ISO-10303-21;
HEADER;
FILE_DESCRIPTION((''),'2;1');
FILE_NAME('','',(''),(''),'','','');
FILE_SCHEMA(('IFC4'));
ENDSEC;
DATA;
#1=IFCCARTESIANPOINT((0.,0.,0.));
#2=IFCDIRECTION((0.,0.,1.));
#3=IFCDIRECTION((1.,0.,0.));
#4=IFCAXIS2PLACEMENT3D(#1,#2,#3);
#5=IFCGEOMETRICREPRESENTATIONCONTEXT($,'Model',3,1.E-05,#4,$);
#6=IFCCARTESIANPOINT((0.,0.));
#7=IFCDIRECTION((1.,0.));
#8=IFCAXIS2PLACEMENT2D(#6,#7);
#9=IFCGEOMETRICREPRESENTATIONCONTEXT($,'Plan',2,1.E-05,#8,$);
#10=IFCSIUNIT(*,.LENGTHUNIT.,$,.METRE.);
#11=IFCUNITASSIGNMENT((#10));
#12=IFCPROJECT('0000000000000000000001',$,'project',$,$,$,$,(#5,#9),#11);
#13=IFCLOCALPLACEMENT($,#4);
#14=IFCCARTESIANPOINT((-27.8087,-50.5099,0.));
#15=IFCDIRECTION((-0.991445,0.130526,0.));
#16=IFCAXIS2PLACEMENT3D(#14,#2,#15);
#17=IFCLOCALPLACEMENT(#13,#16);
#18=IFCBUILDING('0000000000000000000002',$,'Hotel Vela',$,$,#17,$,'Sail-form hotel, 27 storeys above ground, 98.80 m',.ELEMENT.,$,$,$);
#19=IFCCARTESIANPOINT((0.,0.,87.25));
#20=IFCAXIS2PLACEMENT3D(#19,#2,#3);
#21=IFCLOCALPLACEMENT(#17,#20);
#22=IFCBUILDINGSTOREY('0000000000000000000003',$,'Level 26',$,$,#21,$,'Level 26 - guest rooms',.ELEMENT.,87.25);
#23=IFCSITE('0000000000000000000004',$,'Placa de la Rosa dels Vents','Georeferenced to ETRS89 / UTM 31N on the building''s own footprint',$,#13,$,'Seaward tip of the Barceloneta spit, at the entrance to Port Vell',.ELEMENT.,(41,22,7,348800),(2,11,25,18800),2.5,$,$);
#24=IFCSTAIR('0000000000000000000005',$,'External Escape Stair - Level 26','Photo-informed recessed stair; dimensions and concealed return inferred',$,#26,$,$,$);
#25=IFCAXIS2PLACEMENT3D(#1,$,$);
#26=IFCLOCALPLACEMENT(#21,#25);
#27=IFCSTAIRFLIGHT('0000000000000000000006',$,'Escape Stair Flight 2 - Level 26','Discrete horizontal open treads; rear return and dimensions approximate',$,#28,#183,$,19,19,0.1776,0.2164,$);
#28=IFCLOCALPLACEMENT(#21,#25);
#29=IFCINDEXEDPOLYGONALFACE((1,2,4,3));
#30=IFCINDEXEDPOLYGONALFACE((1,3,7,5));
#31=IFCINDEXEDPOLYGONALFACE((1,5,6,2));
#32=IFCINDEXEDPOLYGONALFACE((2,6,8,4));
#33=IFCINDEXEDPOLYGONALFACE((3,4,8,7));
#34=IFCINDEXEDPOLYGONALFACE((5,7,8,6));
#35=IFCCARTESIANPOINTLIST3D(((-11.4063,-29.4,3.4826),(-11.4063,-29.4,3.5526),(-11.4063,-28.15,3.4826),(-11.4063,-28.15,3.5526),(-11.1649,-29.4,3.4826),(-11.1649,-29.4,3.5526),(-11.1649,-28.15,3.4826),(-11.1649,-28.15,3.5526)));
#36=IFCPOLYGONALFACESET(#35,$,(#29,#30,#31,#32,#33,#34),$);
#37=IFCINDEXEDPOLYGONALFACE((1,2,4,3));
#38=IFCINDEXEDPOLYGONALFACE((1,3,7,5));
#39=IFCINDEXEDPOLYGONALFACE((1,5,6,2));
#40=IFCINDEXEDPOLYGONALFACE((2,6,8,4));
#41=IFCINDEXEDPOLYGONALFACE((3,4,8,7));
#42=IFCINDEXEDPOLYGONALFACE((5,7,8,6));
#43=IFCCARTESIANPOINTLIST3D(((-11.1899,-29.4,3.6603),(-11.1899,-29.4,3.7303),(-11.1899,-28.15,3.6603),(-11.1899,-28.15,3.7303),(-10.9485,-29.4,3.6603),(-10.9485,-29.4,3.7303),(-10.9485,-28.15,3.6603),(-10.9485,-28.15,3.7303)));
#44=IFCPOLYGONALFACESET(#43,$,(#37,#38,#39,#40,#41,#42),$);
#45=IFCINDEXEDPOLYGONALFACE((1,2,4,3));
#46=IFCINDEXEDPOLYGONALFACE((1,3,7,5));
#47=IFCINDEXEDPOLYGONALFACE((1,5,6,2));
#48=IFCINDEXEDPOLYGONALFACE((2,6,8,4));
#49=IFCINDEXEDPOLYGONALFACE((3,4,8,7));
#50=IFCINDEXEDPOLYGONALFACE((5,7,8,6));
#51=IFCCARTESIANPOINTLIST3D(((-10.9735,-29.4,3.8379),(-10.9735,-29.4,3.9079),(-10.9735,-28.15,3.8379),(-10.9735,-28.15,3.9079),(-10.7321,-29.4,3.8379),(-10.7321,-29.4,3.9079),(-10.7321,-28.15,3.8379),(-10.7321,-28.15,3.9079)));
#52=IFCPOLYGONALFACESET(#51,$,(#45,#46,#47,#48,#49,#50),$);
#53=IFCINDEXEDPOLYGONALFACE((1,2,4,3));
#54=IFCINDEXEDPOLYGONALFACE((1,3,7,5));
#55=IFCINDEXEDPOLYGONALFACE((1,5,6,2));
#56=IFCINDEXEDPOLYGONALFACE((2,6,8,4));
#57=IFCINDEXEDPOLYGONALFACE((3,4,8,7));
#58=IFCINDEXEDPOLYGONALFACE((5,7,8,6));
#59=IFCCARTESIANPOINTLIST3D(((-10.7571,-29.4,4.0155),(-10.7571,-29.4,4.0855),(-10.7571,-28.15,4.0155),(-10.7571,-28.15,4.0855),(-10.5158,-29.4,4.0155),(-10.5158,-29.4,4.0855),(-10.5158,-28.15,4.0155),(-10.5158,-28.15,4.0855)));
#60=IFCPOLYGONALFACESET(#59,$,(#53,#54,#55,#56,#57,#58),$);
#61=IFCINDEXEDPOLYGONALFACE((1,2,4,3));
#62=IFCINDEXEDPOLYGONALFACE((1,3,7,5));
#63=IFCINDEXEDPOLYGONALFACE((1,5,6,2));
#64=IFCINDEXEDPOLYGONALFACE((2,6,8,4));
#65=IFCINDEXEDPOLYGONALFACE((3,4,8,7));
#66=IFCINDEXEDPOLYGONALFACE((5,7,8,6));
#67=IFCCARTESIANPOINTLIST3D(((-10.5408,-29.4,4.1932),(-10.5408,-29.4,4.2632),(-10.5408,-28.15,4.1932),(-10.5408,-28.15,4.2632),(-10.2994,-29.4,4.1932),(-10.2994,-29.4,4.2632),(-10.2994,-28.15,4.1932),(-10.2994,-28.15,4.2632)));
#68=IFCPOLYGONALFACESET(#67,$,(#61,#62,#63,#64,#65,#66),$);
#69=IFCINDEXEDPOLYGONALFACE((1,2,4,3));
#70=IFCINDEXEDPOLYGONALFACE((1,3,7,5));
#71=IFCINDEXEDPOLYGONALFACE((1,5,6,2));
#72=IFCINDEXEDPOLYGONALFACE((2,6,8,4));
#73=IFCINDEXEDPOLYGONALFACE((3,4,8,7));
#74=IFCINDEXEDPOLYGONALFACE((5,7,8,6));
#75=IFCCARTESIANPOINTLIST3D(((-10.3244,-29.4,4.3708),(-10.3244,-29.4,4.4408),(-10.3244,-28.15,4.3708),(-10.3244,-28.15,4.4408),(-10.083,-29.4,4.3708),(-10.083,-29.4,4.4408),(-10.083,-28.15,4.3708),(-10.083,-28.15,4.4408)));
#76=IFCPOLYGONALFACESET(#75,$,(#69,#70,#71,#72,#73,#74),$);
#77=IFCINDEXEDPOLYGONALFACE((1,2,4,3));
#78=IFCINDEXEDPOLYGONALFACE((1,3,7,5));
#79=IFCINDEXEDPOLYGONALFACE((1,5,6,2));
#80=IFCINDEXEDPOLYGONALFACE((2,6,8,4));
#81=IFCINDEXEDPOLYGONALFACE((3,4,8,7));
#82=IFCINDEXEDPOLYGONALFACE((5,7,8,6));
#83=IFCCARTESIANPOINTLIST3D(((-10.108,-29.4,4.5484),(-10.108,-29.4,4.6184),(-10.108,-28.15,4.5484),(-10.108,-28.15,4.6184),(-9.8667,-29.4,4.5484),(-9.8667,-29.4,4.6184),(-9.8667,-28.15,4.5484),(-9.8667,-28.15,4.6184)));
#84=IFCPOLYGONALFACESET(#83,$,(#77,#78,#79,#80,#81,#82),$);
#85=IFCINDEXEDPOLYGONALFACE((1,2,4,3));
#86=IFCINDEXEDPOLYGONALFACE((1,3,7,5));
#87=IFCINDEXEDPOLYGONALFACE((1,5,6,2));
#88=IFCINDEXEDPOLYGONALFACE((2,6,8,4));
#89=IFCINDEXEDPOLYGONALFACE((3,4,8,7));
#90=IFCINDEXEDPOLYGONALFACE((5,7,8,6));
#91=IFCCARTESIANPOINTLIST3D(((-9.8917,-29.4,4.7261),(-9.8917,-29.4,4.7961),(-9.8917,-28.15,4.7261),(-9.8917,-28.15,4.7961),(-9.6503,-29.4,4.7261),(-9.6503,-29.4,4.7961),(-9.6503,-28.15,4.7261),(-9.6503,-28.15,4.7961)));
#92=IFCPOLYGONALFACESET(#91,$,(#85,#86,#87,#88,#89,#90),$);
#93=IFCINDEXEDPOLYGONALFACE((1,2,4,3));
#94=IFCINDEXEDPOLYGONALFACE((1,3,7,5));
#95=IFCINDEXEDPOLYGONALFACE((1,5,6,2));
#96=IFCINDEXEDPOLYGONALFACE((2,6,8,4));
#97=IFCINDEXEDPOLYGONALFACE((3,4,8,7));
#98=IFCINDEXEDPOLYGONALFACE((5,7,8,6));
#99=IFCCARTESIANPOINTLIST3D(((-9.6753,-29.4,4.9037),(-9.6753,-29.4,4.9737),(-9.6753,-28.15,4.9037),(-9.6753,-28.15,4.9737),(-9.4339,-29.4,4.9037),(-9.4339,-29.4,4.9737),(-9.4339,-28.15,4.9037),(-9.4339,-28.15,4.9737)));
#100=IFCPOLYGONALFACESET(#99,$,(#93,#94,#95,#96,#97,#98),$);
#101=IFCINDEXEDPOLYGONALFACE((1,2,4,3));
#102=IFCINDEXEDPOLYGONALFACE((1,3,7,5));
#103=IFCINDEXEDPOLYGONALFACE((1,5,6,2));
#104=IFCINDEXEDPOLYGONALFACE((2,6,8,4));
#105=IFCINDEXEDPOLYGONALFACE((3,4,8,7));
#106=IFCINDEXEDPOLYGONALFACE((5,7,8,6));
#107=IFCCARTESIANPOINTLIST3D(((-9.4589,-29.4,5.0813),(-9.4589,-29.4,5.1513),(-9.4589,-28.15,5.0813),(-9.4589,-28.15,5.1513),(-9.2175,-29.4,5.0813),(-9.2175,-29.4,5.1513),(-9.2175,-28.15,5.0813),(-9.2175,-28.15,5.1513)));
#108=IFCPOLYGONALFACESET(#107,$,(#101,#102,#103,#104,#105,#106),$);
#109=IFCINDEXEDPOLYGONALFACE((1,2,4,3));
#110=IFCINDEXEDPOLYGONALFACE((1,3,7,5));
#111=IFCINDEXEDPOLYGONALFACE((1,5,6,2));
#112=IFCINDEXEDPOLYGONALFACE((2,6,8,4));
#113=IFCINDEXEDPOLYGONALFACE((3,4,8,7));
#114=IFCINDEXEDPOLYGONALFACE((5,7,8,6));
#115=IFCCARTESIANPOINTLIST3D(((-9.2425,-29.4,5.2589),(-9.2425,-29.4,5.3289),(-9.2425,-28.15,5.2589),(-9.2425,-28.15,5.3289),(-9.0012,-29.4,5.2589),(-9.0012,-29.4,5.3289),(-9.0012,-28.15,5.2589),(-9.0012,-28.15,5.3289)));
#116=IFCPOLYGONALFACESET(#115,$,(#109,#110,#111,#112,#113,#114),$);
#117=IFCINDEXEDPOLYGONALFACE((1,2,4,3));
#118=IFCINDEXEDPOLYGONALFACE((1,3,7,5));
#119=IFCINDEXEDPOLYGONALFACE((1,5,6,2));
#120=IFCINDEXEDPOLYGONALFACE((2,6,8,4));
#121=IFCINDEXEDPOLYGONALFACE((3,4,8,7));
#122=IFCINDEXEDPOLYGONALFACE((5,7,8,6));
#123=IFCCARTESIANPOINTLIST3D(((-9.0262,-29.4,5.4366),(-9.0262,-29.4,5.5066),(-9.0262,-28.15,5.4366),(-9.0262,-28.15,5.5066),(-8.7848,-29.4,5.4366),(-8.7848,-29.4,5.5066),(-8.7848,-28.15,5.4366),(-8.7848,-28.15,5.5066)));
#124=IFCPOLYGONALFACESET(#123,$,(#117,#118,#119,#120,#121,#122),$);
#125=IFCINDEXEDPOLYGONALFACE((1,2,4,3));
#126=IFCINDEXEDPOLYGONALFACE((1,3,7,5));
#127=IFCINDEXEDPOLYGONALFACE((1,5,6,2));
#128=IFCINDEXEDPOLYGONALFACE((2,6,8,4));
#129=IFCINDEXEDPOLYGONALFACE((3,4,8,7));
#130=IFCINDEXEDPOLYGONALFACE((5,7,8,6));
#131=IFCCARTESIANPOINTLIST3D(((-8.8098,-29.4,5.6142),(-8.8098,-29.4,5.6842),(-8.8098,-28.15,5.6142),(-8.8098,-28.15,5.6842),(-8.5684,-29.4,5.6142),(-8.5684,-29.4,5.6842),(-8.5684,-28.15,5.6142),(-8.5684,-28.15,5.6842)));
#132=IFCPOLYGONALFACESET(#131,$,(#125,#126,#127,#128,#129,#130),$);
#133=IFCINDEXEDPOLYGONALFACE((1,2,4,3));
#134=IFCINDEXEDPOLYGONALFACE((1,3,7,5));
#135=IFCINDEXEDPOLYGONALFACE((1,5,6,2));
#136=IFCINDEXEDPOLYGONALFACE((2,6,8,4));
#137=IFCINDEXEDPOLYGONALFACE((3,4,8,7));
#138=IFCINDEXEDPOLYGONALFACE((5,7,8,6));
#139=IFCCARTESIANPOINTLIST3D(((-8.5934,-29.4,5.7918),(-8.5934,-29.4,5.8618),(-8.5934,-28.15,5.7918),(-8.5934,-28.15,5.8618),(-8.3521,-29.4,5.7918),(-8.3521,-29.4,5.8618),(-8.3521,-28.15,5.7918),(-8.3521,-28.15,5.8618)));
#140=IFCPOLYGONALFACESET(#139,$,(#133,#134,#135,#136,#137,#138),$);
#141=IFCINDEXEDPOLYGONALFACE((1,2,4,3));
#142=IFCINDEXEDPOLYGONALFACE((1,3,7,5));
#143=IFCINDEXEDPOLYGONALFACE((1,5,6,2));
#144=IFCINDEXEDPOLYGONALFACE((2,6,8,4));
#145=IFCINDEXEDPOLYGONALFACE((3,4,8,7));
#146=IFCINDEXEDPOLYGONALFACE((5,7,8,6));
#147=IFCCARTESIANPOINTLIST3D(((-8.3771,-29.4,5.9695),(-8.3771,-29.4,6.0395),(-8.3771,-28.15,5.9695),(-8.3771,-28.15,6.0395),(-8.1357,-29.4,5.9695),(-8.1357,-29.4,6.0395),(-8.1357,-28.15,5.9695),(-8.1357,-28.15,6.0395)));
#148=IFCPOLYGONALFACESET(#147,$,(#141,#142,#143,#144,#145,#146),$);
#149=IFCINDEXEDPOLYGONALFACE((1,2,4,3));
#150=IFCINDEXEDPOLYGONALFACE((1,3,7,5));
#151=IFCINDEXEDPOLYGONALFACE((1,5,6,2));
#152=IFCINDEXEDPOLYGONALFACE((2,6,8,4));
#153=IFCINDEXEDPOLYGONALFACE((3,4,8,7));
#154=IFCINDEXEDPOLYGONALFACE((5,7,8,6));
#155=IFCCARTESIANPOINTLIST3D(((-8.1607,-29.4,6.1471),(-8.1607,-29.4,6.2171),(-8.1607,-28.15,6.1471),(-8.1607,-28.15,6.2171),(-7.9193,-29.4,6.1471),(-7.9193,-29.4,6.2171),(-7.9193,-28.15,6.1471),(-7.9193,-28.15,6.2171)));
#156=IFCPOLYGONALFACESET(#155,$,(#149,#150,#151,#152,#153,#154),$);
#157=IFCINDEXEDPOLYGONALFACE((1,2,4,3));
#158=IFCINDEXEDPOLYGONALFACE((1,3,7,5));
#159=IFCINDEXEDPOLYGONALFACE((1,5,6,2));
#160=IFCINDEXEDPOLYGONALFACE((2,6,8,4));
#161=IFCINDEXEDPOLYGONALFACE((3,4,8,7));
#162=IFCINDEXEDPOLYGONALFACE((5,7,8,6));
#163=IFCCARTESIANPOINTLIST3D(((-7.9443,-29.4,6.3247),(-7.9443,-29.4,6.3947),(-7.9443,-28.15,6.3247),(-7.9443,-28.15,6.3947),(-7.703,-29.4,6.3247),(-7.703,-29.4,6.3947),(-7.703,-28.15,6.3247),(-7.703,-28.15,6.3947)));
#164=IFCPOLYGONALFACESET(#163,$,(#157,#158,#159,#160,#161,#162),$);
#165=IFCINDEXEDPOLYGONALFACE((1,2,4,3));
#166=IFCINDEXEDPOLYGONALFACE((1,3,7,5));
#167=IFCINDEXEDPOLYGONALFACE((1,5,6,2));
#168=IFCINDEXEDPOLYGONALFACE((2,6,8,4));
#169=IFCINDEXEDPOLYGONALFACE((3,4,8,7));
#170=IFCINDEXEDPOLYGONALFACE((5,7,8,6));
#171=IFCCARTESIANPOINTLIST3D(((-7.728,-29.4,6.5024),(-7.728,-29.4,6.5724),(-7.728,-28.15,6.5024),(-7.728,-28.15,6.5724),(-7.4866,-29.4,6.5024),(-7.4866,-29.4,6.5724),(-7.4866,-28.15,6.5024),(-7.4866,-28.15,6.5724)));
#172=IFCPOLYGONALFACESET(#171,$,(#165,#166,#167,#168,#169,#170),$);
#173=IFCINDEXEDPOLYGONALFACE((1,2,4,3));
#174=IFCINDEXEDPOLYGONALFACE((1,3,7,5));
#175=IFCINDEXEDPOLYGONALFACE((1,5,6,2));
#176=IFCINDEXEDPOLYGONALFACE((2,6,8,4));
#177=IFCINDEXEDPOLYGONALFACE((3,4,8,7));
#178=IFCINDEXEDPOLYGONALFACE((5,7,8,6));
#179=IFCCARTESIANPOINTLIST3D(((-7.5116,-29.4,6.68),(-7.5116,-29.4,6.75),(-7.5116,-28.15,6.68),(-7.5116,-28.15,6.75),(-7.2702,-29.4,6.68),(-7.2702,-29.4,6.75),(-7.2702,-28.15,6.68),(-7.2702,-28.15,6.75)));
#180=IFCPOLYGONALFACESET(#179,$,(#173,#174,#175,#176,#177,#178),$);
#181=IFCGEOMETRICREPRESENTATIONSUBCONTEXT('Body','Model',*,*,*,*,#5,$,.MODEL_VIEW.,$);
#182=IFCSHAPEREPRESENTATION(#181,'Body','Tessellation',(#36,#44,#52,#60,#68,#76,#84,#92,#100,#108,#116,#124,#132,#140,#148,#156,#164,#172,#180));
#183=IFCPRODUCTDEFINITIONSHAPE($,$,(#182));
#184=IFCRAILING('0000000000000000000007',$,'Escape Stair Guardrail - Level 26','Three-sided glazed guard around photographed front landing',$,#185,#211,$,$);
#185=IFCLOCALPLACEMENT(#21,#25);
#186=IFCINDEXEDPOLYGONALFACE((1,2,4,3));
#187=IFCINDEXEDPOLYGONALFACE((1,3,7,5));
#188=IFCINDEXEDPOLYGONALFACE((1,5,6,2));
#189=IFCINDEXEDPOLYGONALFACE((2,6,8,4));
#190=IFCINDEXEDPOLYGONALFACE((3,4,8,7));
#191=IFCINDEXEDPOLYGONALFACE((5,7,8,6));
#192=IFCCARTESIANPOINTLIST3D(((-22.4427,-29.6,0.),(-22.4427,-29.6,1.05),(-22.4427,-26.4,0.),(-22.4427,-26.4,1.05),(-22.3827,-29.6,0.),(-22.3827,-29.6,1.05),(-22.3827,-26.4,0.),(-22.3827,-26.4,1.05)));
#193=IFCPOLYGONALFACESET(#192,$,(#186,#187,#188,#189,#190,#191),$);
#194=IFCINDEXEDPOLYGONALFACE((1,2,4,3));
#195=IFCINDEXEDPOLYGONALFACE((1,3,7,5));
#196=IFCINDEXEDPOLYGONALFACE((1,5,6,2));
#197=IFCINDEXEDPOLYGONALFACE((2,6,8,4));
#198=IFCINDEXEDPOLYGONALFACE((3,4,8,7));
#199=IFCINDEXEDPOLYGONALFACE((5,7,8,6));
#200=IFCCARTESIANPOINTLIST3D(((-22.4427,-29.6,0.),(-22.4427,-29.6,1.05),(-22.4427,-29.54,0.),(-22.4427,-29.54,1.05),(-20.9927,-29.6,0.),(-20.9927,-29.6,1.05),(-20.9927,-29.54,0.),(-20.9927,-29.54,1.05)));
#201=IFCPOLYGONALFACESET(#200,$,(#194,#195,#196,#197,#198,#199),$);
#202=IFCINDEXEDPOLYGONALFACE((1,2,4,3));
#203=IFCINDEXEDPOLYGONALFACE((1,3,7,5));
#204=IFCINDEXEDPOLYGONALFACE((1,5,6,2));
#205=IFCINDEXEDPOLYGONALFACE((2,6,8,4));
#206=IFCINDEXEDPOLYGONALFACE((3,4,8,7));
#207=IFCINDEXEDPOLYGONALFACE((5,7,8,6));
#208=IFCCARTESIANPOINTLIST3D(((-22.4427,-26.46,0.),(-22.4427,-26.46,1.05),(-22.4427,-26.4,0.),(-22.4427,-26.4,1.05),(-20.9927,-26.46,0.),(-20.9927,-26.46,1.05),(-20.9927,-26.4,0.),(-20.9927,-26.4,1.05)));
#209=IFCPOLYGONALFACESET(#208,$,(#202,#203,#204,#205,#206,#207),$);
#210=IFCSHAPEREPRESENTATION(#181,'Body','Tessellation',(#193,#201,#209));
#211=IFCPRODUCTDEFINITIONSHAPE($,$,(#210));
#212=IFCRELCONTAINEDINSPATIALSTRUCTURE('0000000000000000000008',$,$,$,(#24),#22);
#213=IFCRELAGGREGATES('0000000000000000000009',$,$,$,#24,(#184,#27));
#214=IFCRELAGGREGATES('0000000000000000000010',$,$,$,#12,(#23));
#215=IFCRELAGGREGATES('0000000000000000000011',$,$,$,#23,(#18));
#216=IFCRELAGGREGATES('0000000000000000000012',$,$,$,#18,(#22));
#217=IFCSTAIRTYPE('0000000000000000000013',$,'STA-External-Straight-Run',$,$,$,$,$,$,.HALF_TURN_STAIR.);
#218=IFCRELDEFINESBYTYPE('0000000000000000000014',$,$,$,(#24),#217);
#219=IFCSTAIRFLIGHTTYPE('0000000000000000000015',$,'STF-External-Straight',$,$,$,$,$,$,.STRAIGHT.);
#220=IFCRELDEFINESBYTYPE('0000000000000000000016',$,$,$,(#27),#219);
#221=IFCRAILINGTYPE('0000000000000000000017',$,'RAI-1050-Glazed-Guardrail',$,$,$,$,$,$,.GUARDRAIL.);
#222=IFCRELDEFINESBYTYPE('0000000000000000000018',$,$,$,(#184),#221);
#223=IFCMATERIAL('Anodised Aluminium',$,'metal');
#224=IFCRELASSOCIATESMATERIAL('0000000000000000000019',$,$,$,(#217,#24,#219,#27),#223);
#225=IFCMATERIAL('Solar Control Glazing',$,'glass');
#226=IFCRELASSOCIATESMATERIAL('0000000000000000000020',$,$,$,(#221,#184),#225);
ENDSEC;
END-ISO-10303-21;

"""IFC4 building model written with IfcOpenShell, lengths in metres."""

from ifc_helpers import new_model, si_unit, frame, origin_with_axes, origin_2d_with_axis, place, context, subcontext, project, spatial, line, indexed_curve, outline, extrude, material, type_object, element, aggregate, save


model = new_model("IFC4")

# Units and contexts
model_context = context("Model", 3, precision=1e-05, world=origin_with_axes())
plan_context = context("Plan", 2, precision=1e-05, world=origin_2d_with_axis())
body_context = subcontext(model_context, "Body", "Model", "MODEL_VIEW")
ifc_project = project(units=[si_unit("LENGTHUNIT", "METRE")], contexts=[model_context, plan_context])

# Site, building, storey
site_placement = place(None, origin_with_axes())
site = spatial("IfcSite", under=ifc_project, at=site_placement, Name="Placa de la Rosa dels Vents", Description="Georeferenced to ETRS89 / UTM 31N on the building's own footprint", LongName="Seaward tip of the Barceloneta spit, at the entrance to Port Vell", CompositionType="ELEMENT", RefLatitude=(41, 22, 7, 348800), RefLongitude=(2, 11, 25, 18800), RefElevation=2.5)
building_placement = place(site_placement, frame((-27.8087, -50.5099, 0.0), z_axis=(0.0, 0.0, 1.0), x_axis=(-0.991445, 0.130526, 0.0)))
building = spatial("IfcBuilding", under=site, at=building_placement, Name="Hotel Vela", LongName="Sail-form hotel, 27 storeys above ground, 98.80 m", CompositionType="ELEMENT")
storey_placement = place(building_placement, frame((0.0, 0.0, 87.25), z_axis=(0.0, 0.0, 1.0), x_axis=(1.0, 0.0, 0.0)))
storey = spatial("IfcBuildingStorey", under=building, at=storey_placement, Name="Level 26", LongName="Level 26 - guest rooms", CompositionType="ELEMENT", Elevation=87.25)

# Stair
ifc_material_1 = material(Name="Anodised Aluminium", Category="metal")
stair_type = type_object("IfcStairType", Name="STA-External-Straight-Run", PredefinedType="HALF_TURN_STAIR", material=ifc_material_1)
stair_placement = place(storey_placement, frame((0.0, 0.0, -87.25), z_axis=(0.0, 0.0, 1.0), x_axis=(1.0, 0.0, 0.0)))
stair = element("IfcStair", 1, at=stair_placement, inside=storey, type_object=stair_type, material=ifc_material_1, Name="External Escape Stair - Level 26", Description="Photo-informed recessed stair; dimensions and concealed return inferred")

# Stair flight
stair_flight_type = type_object("IfcStairFlightType", Name="STF-External-Straight", PredefinedType="STRAIGHT", material=ifc_material_1)
stair_flight_1_placement = place(stair_placement, origin_with_axes())
stair_flight_1 = element("IfcStairFlight", 2, at=stair_flight_1_placement, type_object=stair_flight_type, material=ifc_material_1, Name="Escape Stair Flight 2 - Level 26", Description="Discrete horizontal open treads; rear return and dimensions approximate", NumberOfRisers=19, NumberOfTreads=19, RiserHeight=0.1776, TreadLength=0.2164, context=body_context, shape_type="SweptSolid", body=[
    extrude(outline(indexed_curve([(0.0, 0.0), (0.2414, 0.0), (0.2414, 1.25), (0.0, 1.25)], segments=[line(1, 2, 3, 4, 1)])), frame((-11.4063, -29.4, 90.7326), z_axis=(0.0, 0.0, 1.0), x_axis=(1.0, 0.0, 0.0)), (0.0, 0.0, 1.0), 0.07),
    extrude(outline(indexed_curve([(0.0, 0.0), (0.2414, 0.0), (0.2414, 1.25), (0.0, 1.25)], segments=[line(1, 2, 3, 4, 1)])), frame((-11.1899, -29.4, 90.9103), z_axis=(0.0, 0.0, 1.0), x_axis=(1.0, 0.0, 0.0)), (0.0, 0.0, 1.0), 0.07),
    extrude(outline(indexed_curve([(0.0, 0.0), (0.2414, 0.0), (0.2414, 1.25), (0.0, 1.25)], segments=[line(1, 2, 3, 4, 1)])), frame((-10.9735, -29.4, 91.0879), z_axis=(0.0, 0.0, 1.0), x_axis=(1.0, 0.0, 0.0)), (0.0, 0.0, 1.0), 0.07),
    extrude(outline(indexed_curve([(0.0, 0.0), (0.2414, 0.0), (0.2414, 1.25), (0.0, 1.25)], segments=[line(1, 2, 3, 4, 1)])), frame((-10.7571, -29.4, 91.2655), z_axis=(0.0, 0.0, 1.0), x_axis=(1.0, 0.0, 0.0)), (0.0, 0.0, 1.0), 0.07),
    extrude(outline(indexed_curve([(0.0, 0.0), (0.2414, 0.0), (0.2414, 1.25), (0.0, 1.25)], segments=[line(1, 2, 3, 4, 1)])), frame((-10.5408, -29.4, 91.4432), z_axis=(0.0, 0.0, 1.0), x_axis=(1.0, 0.0, 0.0)), (0.0, 0.0, 1.0), 0.07),
    extrude(outline(indexed_curve([(0.0, 0.0), (0.2414, 0.0), (0.2414, 1.25), (0.0, 1.25)], segments=[line(1, 2, 3, 4, 1)])), frame((-10.3244, -29.4, 91.6208), z_axis=(0.0, 0.0, 1.0), x_axis=(1.0, 0.0, 0.0)), (0.0, 0.0, 1.0), 0.07),
    extrude(outline(indexed_curve([(0.0, 0.0), (0.2414, 0.0), (0.2414, 1.25), (0.0, 1.25)], segments=[line(1, 2, 3, 4, 1)])), frame((-10.108, -29.4, 91.7984), z_axis=(0.0, 0.0, 1.0), x_axis=(1.0, 0.0, 0.0)), (0.0, 0.0, 1.0), 0.07),
    extrude(outline(indexed_curve([(0.0, 0.0), (0.2414, 0.0), (0.2414, 1.25), (0.0, 1.25)], segments=[line(1, 2, 3, 4, 1)])), frame((-9.8917, -29.4, 91.9761), z_axis=(0.0, 0.0, 1.0), x_axis=(1.0, 0.0, 0.0)), (0.0, 0.0, 1.0), 0.07),
    extrude(outline(indexed_curve([(0.0, 0.0), (0.2414, 0.0), (0.2414, 1.25), (0.0, 1.25)], segments=[line(1, 2, 3, 4, 1)])), frame((-9.6753, -29.4, 92.1537), z_axis=(0.0, 0.0, 1.0), x_axis=(1.0, 0.0, 0.0)), (0.0, 0.0, 1.0), 0.07),
    extrude(outline(indexed_curve([(0.0, 0.0), (0.2414, 0.0), (0.2414, 1.25), (0.0, 1.25)], segments=[line(1, 2, 3, 4, 1)])), frame((-9.4589, -29.4, 92.3313), z_axis=(0.0, 0.0, 1.0), x_axis=(1.0, 0.0, 0.0)), (0.0, 0.0, 1.0), 0.07),
    extrude(outline(indexed_curve([(0.0, 0.0), (0.2414, 0.0), (0.2414, 1.25), (0.0, 1.25)], segments=[line(1, 2, 3, 4, 1)])), frame((-9.2425, -29.4, 92.5089), z_axis=(0.0, 0.0, 1.0), x_axis=(1.0, 0.0, 0.0)), (0.0, 0.0, 1.0), 0.07),
    extrude(outline(indexed_curve([(0.0, 0.0), (0.2414, 0.0), (0.2414, 1.25), (0.0, 1.25)], segments=[line(1, 2, 3, 4, 1)])), frame((-9.0262, -29.4, 92.6866), z_axis=(0.0, 0.0, 1.0), x_axis=(1.0, 0.0, 0.0)), (0.0, 0.0, 1.0), 0.07),
    extrude(outline(indexed_curve([(0.0, 0.0), (0.2414, 0.0), (0.2414, 1.25), (0.0, 1.25)], segments=[line(1, 2, 3, 4, 1)])), frame((-8.8098, -29.4, 92.8642), z_axis=(0.0, 0.0, 1.0), x_axis=(1.0, 0.0, 0.0)), (0.0, 0.0, 1.0), 0.07),
    extrude(outline(indexed_curve([(0.0, 0.0), (0.2414, 0.0), (0.2414, 1.25), (0.0, 1.25)], segments=[line(1, 2, 3, 4, 1)])), frame((-8.5934, -29.4, 93.0418), z_axis=(0.0, 0.0, 1.0), x_axis=(1.0, 0.0, 0.0)), (0.0, 0.0, 1.0), 0.07),
    extrude(outline(indexed_curve([(0.0, 0.0), (0.2414, 0.0), (0.2414, 1.25), (0.0, 1.25)], segments=[line(1, 2, 3, 4, 1)])), frame((-8.3771, -29.4, 93.2195), z_axis=(0.0, 0.0, 1.0), x_axis=(1.0, 0.0, 0.0)), (0.0, 0.0, 1.0), 0.07),
    extrude(outline(indexed_curve([(0.0, 0.0), (0.2414, 0.0), (0.2414, 1.25), (0.0, 1.25)], segments=[line(1, 2, 3, 4, 1)])), frame((-8.1607, -29.4, 93.3971), z_axis=(0.0, 0.0, 1.0), x_axis=(1.0, 0.0, 0.0)), (0.0, 0.0, 1.0), 0.07),
    extrude(outline(indexed_curve([(0.0, 0.0), (0.2414, 0.0), (0.2414, 1.25), (0.0, 1.25)], segments=[line(1, 2, 3, 4, 1)])), frame((-7.9443, -29.4, 93.5747), z_axis=(0.0, 0.0, 1.0), x_axis=(1.0, 0.0, 0.0)), (0.0, 0.0, 1.0), 0.07),
    extrude(outline(indexed_curve([(0.0, 0.0), (0.2414, 0.0), (0.2414, 1.25), (0.0, 1.25)], segments=[line(1, 2, 3, 4, 1)])), frame((-7.728, -29.4, 93.7524), z_axis=(0.0, 0.0, 1.0), x_axis=(1.0, 0.0, 0.0)), (0.0, 0.0, 1.0), 0.07),
    extrude(outline(indexed_curve([(0.0, 0.0), (0.2414, 0.0), (0.2414, 1.25), (0.0, 1.25)], segments=[line(1, 2, 3, 4, 1)])), frame((-7.5116, -29.4, 93.93), z_axis=(0.0, 0.0, 1.0), x_axis=(1.0, 0.0, 0.0)), (0.0, 0.0, 1.0), 0.07),
])

# Railing
ifc_material_2 = material(Name="Solar Control Glazing", Category="glass")
railing_type = type_object("IfcRailingType", Name="RAI-1050-Glazed-Guardrail", PredefinedType="GUARDRAIL", material=ifc_material_2)
railing_placement = place(stair_placement, origin_with_axes())
railing = element("IfcRailing", 3, at=railing_placement, type_object=railing_type, material=ifc_material_2, Name="Escape Stair Guardrail - Level 26", Description="Three-sided glazed guard around photographed front landing", context=body_context, shape_type="SweptSolid", body=[
    extrude(outline(indexed_curve([(0.0, 0.0), (0.06, 0.0), (0.06, 3.2), (0.0, 3.2)], segments=[line(1, 2, 3, 4, 1)])), frame((-22.4427, -29.6, 87.25), z_axis=(0.0, 0.0, 1.0), x_axis=(1.0, 0.0, 0.0)), (0.0, 0.0, 1.0), 1.05),
    extrude(outline(indexed_curve([(0.0, 0.0), (1.45, 0.0), (1.45, 0.06), (0.0, 0.06)], segments=[line(1, 2, 3, 4, 1)])), frame((-22.4427, -29.6, 87.25), z_axis=(0.0, 0.0, 1.0), x_axis=(1.0, 0.0, 0.0)), (0.0, 0.0, 1.0), 1.05),
    extrude(outline(indexed_curve([(0.0, 0.0), (1.45, 0.0), (1.45, 0.06), (0.0, 0.06)], segments=[line(1, 2, 3, 4, 1)])), frame((-22.4427, -26.46, 87.25), z_axis=(0.0, 0.0, 1.0), x_axis=(1.0, 0.0, 0.0)), (0.0, 0.0, 1.0), 1.05),
])
aggregate(stair, [railing, stair_flight_1])

save(model, "model.ifc")
